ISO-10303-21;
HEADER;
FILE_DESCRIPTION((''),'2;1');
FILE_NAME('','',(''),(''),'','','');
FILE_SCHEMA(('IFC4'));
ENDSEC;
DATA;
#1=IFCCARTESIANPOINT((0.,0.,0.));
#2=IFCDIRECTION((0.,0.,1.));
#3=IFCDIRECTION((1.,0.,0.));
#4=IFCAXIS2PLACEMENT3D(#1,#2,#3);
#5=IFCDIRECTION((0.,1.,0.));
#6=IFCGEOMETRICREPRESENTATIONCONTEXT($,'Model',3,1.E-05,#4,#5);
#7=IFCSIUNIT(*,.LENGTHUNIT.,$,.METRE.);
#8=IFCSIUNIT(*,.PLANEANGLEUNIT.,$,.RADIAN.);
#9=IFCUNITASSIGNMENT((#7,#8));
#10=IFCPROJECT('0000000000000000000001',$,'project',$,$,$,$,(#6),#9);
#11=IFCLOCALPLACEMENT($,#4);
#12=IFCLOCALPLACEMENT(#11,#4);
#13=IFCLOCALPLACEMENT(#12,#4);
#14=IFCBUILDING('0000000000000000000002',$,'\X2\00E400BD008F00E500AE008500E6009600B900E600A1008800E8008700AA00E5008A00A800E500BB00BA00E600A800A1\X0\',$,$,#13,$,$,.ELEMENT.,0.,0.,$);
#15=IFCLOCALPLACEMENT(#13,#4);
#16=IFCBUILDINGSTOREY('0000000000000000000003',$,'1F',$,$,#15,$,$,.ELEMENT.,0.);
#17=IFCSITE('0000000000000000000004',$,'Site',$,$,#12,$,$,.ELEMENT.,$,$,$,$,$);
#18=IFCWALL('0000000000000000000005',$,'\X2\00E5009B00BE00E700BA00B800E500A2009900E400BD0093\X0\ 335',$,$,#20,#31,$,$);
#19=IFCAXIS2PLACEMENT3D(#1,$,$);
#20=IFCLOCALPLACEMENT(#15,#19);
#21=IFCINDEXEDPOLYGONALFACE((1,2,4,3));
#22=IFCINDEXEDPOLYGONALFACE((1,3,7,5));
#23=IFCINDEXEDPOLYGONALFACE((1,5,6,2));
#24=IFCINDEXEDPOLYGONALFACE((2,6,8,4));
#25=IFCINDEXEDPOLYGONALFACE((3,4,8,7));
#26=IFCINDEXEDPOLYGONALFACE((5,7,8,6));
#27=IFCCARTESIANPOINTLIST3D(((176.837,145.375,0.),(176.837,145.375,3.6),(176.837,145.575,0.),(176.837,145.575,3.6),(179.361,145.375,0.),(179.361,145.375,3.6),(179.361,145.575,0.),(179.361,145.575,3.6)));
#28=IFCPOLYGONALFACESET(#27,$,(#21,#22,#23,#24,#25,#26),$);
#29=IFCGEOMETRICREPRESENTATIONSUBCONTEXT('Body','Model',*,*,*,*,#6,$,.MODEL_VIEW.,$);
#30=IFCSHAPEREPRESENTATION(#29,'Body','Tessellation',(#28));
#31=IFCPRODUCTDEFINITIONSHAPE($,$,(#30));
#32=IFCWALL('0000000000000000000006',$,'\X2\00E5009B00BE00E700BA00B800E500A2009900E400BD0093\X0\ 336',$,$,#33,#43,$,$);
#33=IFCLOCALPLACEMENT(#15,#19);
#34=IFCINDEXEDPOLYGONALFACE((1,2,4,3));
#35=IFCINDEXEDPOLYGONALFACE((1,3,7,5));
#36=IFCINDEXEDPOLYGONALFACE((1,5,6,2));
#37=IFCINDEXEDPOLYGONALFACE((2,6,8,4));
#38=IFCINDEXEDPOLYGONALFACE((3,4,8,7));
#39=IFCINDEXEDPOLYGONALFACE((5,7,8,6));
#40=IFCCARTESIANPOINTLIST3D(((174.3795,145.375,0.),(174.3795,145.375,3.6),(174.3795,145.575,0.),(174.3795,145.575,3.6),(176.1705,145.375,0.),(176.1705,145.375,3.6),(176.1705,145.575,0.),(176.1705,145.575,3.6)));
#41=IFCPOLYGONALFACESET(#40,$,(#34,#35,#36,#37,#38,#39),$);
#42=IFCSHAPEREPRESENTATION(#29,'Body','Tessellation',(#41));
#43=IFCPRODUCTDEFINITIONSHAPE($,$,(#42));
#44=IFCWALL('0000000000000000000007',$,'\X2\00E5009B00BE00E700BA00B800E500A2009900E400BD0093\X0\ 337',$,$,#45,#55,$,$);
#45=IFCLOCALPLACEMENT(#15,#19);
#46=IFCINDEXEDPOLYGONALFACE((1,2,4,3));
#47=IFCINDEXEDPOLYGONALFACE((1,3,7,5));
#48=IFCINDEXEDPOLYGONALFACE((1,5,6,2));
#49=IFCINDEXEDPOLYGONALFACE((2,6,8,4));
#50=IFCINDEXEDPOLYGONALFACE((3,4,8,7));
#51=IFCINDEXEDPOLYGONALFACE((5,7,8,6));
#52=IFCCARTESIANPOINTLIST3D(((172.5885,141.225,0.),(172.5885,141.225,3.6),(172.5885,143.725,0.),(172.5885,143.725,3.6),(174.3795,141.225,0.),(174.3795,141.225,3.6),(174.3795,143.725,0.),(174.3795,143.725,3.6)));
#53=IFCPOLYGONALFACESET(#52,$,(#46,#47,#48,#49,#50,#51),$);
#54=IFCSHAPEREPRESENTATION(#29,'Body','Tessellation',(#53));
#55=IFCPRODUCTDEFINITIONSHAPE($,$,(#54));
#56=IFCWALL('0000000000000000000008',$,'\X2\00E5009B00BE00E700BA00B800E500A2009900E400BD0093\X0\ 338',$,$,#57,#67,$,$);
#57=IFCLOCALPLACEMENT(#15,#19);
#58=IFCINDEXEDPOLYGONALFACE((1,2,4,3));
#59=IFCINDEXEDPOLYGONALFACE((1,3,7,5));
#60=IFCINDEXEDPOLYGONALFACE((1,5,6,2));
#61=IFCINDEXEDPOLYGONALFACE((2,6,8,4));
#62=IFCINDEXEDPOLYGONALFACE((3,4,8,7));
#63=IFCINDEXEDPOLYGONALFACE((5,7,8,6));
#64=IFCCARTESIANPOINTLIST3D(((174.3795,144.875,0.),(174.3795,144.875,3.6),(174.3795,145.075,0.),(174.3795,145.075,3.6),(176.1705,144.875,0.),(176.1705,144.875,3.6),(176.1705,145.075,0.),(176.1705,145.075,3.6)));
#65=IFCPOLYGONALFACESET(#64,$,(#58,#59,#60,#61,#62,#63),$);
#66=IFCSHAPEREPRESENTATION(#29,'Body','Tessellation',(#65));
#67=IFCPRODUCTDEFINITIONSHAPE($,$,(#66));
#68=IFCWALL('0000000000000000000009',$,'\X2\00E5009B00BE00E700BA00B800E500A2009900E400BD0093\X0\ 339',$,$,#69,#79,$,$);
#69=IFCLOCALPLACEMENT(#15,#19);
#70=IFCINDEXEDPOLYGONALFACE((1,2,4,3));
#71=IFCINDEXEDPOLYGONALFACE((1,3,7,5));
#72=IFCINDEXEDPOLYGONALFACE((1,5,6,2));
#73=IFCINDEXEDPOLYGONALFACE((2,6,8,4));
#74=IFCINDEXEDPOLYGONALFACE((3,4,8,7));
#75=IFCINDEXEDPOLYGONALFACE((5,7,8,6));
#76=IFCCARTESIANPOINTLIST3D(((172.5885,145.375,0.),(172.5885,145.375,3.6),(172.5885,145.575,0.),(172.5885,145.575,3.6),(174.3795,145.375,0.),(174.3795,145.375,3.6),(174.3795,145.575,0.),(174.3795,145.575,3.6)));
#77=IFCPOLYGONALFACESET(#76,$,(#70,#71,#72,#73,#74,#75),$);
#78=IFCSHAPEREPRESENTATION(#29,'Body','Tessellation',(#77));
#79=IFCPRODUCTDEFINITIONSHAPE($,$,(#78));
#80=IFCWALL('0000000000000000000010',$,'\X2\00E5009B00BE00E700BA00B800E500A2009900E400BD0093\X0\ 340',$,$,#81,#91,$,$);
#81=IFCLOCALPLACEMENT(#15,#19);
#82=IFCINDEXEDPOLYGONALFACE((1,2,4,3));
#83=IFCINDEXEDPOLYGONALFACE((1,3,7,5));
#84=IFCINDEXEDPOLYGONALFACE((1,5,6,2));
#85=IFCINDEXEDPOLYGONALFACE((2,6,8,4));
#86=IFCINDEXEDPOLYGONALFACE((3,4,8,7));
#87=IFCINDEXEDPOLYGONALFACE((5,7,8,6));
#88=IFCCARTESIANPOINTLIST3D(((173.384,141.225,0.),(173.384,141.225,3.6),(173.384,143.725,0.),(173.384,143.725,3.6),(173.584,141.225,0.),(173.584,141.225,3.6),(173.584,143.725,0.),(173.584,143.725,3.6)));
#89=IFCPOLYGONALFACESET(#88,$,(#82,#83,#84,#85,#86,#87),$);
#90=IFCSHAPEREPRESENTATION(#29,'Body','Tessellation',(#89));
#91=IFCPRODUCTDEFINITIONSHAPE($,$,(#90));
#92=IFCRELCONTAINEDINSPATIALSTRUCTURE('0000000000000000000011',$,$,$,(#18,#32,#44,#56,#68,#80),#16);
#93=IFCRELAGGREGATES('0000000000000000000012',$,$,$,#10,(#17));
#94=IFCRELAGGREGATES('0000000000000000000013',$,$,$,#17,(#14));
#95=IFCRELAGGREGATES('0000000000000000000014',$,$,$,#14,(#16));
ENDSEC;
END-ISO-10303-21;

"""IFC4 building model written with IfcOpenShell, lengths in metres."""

from ifc_helpers import new_model, si_unit, direction, frame, frame_2d, origin_with_axes, place, context, subcontext, project, spatial, rectangle, extrude, element, save


model = new_model("IFC4")

# Units and contexts
model_context = context("Model", 3, precision=1e-05, world=origin_with_axes(), true_north=direction((0.0, 1.0, 0.0)))
body_context = subcontext(model_context, "Body", "Model", "MODEL_VIEW")
ifc_project = project(units=[si_unit("LENGTHUNIT", "METRE"), si_unit("PLANEANGLEUNIT", "RADIAN")], contexts=[model_context])

# Site, building, storey
placement = place(None, origin_with_axes())
site_placement = place(placement, origin_with_axes())
site = spatial("IfcSite", under=ifc_project, at=site_placement, Name="Site", CompositionType="ELEMENT")
building_placement = place(site_placement, origin_with_axes())
building = spatial("IfcBuilding", under=site, at=building_placement, Name="ä½\u008få®\u0085æ\u0096¹æ¡\u0088è\u0087ªå\u008a¨å»ºæ¨¡", CompositionType="ELEMENT", ElevationOfRefHeight=0.0, ElevationOfTerrain=0.0)
storey_placement = place(building_placement, origin_with_axes())
storey = spatial("IfcBuildingStorey", under=building, at=storey_placement, Name="1F", CompositionType="ELEMENT", Elevation=0.0)

# Walls
for number, where, z_axis, x_axis, name in (
    (1, (178.099, 145.475, 0.0), (0.0, 0.0, 1.0), (-1.0, 0.0, 0.0), "å\u009b¾çº¸å¢\u0099ä½\u0093 335"),
):
    element("IfcWall", number, at=place(storey_placement, frame(where, z_axis=z_axis, x_axis=x_axis)), inside=storey, Name=name, context=body_context, shape_type="SweptSolid", body=[
        extrude(rectangle(XDim=2.524, YDim=0.2, at=frame_2d((0.0, 0.0), x_axis=(1.0, 0.0, 0.0))), frame((0.0, 0.0, 0.0), z_axis=(0.0, 0.0, 1.0)), (0.0, 0.0, 1.0), 3.6),
    ])
wall_1_placement = place(storey_placement, frame((175.275, 145.475, 0.0), z_axis=(0.0, 0.0, 1.0), x_axis=(-1.0, 0.0, 0.0)))
element("IfcWall", 2, at=wall_1_placement, inside=storey, Name="å\u009b¾çº¸å¢\u0099ä½\u0093 336", context=body_context, shape_type="SweptSolid", body=[
    extrude(rectangle(XDim=1.791, YDim=0.2, at=frame_2d((0.0, 0.0), x_axis=(1.0, 0.0, 0.0))), frame((0.0, 0.0, 0.0), z_axis=(0.0, 0.0, 1.0)), (0.0, 0.0, 1.0), 3.6),
])
wall_2_placement = place(storey_placement, frame((173.484, 142.475, 0.0), z_axis=(0.0, 0.0, 1.0), x_axis=(1.0, 0.0, 0.0)))
element("IfcWall", 3, at=wall_2_placement, inside=storey, Name="å\u009b¾çº¸å¢\u0099ä½\u0093 337", context=body_context, shape_type="SweptSolid", body=[
    extrude(rectangle(XDim=1.791, YDim=2.5, at=frame_2d((0.0, 0.0), x_axis=(1.0, 0.0, 0.0))), frame((0.0, 0.0, 0.0), z_axis=(0.0, 0.0, 1.0)), (0.0, 0.0, 1.0), 3.6),
])
for number, where, z_axis, x_axis, name in (
    (4, (175.275, 144.975, 0.0), (0.0, 0.0, 1.0), (-1.0, 0.0, 0.0), "å\u009b¾çº¸å¢\u0099ä½\u0093 338"),
    (5, (173.484, 145.475, 0.0), (0.0, 0.0, 1.0), (1.0, 0.0, 0.0), "å\u009b¾çº¸å¢\u0099ä½\u0093 339"),
):
    element("IfcWall", number, at=place(storey_placement, frame(where, z_axis=z_axis, x_axis=x_axis)), inside=storey, Name=name, context=body_context, shape_type="SweptSolid", body=[
        extrude(rectangle(XDim=1.791, YDim=0.2, at=frame_2d((0.0, 0.0), x_axis=(1.0, 0.0, 0.0))), frame((0.0, 0.0, 0.0), z_axis=(0.0, 0.0, 1.0)), (0.0, 0.0, 1.0), 3.6),
    ])
wall_3_placement = place(storey_placement, frame((173.484, 142.475, 0.0), z_axis=(0.0, 0.0, 1.0), x_axis=(0.0, 1.0, 0.0)))
element("IfcWall", 6, at=wall_3_placement, inside=storey, Name="å\u009b¾çº¸å¢\u0099ä½\u0093 340", context=body_context, shape_type="SweptSolid", body=[
    extrude(rectangle(XDim=2.5, YDim=0.2, at=frame_2d((0.0, 0.0), x_axis=(1.0, 0.0, 0.0))), frame((0.0, 0.0, 0.0), z_axis=(0.0, 0.0, 1.0)), (0.0, 0.0, 1.0), 3.6),
])

save(model, "model.ifc")
